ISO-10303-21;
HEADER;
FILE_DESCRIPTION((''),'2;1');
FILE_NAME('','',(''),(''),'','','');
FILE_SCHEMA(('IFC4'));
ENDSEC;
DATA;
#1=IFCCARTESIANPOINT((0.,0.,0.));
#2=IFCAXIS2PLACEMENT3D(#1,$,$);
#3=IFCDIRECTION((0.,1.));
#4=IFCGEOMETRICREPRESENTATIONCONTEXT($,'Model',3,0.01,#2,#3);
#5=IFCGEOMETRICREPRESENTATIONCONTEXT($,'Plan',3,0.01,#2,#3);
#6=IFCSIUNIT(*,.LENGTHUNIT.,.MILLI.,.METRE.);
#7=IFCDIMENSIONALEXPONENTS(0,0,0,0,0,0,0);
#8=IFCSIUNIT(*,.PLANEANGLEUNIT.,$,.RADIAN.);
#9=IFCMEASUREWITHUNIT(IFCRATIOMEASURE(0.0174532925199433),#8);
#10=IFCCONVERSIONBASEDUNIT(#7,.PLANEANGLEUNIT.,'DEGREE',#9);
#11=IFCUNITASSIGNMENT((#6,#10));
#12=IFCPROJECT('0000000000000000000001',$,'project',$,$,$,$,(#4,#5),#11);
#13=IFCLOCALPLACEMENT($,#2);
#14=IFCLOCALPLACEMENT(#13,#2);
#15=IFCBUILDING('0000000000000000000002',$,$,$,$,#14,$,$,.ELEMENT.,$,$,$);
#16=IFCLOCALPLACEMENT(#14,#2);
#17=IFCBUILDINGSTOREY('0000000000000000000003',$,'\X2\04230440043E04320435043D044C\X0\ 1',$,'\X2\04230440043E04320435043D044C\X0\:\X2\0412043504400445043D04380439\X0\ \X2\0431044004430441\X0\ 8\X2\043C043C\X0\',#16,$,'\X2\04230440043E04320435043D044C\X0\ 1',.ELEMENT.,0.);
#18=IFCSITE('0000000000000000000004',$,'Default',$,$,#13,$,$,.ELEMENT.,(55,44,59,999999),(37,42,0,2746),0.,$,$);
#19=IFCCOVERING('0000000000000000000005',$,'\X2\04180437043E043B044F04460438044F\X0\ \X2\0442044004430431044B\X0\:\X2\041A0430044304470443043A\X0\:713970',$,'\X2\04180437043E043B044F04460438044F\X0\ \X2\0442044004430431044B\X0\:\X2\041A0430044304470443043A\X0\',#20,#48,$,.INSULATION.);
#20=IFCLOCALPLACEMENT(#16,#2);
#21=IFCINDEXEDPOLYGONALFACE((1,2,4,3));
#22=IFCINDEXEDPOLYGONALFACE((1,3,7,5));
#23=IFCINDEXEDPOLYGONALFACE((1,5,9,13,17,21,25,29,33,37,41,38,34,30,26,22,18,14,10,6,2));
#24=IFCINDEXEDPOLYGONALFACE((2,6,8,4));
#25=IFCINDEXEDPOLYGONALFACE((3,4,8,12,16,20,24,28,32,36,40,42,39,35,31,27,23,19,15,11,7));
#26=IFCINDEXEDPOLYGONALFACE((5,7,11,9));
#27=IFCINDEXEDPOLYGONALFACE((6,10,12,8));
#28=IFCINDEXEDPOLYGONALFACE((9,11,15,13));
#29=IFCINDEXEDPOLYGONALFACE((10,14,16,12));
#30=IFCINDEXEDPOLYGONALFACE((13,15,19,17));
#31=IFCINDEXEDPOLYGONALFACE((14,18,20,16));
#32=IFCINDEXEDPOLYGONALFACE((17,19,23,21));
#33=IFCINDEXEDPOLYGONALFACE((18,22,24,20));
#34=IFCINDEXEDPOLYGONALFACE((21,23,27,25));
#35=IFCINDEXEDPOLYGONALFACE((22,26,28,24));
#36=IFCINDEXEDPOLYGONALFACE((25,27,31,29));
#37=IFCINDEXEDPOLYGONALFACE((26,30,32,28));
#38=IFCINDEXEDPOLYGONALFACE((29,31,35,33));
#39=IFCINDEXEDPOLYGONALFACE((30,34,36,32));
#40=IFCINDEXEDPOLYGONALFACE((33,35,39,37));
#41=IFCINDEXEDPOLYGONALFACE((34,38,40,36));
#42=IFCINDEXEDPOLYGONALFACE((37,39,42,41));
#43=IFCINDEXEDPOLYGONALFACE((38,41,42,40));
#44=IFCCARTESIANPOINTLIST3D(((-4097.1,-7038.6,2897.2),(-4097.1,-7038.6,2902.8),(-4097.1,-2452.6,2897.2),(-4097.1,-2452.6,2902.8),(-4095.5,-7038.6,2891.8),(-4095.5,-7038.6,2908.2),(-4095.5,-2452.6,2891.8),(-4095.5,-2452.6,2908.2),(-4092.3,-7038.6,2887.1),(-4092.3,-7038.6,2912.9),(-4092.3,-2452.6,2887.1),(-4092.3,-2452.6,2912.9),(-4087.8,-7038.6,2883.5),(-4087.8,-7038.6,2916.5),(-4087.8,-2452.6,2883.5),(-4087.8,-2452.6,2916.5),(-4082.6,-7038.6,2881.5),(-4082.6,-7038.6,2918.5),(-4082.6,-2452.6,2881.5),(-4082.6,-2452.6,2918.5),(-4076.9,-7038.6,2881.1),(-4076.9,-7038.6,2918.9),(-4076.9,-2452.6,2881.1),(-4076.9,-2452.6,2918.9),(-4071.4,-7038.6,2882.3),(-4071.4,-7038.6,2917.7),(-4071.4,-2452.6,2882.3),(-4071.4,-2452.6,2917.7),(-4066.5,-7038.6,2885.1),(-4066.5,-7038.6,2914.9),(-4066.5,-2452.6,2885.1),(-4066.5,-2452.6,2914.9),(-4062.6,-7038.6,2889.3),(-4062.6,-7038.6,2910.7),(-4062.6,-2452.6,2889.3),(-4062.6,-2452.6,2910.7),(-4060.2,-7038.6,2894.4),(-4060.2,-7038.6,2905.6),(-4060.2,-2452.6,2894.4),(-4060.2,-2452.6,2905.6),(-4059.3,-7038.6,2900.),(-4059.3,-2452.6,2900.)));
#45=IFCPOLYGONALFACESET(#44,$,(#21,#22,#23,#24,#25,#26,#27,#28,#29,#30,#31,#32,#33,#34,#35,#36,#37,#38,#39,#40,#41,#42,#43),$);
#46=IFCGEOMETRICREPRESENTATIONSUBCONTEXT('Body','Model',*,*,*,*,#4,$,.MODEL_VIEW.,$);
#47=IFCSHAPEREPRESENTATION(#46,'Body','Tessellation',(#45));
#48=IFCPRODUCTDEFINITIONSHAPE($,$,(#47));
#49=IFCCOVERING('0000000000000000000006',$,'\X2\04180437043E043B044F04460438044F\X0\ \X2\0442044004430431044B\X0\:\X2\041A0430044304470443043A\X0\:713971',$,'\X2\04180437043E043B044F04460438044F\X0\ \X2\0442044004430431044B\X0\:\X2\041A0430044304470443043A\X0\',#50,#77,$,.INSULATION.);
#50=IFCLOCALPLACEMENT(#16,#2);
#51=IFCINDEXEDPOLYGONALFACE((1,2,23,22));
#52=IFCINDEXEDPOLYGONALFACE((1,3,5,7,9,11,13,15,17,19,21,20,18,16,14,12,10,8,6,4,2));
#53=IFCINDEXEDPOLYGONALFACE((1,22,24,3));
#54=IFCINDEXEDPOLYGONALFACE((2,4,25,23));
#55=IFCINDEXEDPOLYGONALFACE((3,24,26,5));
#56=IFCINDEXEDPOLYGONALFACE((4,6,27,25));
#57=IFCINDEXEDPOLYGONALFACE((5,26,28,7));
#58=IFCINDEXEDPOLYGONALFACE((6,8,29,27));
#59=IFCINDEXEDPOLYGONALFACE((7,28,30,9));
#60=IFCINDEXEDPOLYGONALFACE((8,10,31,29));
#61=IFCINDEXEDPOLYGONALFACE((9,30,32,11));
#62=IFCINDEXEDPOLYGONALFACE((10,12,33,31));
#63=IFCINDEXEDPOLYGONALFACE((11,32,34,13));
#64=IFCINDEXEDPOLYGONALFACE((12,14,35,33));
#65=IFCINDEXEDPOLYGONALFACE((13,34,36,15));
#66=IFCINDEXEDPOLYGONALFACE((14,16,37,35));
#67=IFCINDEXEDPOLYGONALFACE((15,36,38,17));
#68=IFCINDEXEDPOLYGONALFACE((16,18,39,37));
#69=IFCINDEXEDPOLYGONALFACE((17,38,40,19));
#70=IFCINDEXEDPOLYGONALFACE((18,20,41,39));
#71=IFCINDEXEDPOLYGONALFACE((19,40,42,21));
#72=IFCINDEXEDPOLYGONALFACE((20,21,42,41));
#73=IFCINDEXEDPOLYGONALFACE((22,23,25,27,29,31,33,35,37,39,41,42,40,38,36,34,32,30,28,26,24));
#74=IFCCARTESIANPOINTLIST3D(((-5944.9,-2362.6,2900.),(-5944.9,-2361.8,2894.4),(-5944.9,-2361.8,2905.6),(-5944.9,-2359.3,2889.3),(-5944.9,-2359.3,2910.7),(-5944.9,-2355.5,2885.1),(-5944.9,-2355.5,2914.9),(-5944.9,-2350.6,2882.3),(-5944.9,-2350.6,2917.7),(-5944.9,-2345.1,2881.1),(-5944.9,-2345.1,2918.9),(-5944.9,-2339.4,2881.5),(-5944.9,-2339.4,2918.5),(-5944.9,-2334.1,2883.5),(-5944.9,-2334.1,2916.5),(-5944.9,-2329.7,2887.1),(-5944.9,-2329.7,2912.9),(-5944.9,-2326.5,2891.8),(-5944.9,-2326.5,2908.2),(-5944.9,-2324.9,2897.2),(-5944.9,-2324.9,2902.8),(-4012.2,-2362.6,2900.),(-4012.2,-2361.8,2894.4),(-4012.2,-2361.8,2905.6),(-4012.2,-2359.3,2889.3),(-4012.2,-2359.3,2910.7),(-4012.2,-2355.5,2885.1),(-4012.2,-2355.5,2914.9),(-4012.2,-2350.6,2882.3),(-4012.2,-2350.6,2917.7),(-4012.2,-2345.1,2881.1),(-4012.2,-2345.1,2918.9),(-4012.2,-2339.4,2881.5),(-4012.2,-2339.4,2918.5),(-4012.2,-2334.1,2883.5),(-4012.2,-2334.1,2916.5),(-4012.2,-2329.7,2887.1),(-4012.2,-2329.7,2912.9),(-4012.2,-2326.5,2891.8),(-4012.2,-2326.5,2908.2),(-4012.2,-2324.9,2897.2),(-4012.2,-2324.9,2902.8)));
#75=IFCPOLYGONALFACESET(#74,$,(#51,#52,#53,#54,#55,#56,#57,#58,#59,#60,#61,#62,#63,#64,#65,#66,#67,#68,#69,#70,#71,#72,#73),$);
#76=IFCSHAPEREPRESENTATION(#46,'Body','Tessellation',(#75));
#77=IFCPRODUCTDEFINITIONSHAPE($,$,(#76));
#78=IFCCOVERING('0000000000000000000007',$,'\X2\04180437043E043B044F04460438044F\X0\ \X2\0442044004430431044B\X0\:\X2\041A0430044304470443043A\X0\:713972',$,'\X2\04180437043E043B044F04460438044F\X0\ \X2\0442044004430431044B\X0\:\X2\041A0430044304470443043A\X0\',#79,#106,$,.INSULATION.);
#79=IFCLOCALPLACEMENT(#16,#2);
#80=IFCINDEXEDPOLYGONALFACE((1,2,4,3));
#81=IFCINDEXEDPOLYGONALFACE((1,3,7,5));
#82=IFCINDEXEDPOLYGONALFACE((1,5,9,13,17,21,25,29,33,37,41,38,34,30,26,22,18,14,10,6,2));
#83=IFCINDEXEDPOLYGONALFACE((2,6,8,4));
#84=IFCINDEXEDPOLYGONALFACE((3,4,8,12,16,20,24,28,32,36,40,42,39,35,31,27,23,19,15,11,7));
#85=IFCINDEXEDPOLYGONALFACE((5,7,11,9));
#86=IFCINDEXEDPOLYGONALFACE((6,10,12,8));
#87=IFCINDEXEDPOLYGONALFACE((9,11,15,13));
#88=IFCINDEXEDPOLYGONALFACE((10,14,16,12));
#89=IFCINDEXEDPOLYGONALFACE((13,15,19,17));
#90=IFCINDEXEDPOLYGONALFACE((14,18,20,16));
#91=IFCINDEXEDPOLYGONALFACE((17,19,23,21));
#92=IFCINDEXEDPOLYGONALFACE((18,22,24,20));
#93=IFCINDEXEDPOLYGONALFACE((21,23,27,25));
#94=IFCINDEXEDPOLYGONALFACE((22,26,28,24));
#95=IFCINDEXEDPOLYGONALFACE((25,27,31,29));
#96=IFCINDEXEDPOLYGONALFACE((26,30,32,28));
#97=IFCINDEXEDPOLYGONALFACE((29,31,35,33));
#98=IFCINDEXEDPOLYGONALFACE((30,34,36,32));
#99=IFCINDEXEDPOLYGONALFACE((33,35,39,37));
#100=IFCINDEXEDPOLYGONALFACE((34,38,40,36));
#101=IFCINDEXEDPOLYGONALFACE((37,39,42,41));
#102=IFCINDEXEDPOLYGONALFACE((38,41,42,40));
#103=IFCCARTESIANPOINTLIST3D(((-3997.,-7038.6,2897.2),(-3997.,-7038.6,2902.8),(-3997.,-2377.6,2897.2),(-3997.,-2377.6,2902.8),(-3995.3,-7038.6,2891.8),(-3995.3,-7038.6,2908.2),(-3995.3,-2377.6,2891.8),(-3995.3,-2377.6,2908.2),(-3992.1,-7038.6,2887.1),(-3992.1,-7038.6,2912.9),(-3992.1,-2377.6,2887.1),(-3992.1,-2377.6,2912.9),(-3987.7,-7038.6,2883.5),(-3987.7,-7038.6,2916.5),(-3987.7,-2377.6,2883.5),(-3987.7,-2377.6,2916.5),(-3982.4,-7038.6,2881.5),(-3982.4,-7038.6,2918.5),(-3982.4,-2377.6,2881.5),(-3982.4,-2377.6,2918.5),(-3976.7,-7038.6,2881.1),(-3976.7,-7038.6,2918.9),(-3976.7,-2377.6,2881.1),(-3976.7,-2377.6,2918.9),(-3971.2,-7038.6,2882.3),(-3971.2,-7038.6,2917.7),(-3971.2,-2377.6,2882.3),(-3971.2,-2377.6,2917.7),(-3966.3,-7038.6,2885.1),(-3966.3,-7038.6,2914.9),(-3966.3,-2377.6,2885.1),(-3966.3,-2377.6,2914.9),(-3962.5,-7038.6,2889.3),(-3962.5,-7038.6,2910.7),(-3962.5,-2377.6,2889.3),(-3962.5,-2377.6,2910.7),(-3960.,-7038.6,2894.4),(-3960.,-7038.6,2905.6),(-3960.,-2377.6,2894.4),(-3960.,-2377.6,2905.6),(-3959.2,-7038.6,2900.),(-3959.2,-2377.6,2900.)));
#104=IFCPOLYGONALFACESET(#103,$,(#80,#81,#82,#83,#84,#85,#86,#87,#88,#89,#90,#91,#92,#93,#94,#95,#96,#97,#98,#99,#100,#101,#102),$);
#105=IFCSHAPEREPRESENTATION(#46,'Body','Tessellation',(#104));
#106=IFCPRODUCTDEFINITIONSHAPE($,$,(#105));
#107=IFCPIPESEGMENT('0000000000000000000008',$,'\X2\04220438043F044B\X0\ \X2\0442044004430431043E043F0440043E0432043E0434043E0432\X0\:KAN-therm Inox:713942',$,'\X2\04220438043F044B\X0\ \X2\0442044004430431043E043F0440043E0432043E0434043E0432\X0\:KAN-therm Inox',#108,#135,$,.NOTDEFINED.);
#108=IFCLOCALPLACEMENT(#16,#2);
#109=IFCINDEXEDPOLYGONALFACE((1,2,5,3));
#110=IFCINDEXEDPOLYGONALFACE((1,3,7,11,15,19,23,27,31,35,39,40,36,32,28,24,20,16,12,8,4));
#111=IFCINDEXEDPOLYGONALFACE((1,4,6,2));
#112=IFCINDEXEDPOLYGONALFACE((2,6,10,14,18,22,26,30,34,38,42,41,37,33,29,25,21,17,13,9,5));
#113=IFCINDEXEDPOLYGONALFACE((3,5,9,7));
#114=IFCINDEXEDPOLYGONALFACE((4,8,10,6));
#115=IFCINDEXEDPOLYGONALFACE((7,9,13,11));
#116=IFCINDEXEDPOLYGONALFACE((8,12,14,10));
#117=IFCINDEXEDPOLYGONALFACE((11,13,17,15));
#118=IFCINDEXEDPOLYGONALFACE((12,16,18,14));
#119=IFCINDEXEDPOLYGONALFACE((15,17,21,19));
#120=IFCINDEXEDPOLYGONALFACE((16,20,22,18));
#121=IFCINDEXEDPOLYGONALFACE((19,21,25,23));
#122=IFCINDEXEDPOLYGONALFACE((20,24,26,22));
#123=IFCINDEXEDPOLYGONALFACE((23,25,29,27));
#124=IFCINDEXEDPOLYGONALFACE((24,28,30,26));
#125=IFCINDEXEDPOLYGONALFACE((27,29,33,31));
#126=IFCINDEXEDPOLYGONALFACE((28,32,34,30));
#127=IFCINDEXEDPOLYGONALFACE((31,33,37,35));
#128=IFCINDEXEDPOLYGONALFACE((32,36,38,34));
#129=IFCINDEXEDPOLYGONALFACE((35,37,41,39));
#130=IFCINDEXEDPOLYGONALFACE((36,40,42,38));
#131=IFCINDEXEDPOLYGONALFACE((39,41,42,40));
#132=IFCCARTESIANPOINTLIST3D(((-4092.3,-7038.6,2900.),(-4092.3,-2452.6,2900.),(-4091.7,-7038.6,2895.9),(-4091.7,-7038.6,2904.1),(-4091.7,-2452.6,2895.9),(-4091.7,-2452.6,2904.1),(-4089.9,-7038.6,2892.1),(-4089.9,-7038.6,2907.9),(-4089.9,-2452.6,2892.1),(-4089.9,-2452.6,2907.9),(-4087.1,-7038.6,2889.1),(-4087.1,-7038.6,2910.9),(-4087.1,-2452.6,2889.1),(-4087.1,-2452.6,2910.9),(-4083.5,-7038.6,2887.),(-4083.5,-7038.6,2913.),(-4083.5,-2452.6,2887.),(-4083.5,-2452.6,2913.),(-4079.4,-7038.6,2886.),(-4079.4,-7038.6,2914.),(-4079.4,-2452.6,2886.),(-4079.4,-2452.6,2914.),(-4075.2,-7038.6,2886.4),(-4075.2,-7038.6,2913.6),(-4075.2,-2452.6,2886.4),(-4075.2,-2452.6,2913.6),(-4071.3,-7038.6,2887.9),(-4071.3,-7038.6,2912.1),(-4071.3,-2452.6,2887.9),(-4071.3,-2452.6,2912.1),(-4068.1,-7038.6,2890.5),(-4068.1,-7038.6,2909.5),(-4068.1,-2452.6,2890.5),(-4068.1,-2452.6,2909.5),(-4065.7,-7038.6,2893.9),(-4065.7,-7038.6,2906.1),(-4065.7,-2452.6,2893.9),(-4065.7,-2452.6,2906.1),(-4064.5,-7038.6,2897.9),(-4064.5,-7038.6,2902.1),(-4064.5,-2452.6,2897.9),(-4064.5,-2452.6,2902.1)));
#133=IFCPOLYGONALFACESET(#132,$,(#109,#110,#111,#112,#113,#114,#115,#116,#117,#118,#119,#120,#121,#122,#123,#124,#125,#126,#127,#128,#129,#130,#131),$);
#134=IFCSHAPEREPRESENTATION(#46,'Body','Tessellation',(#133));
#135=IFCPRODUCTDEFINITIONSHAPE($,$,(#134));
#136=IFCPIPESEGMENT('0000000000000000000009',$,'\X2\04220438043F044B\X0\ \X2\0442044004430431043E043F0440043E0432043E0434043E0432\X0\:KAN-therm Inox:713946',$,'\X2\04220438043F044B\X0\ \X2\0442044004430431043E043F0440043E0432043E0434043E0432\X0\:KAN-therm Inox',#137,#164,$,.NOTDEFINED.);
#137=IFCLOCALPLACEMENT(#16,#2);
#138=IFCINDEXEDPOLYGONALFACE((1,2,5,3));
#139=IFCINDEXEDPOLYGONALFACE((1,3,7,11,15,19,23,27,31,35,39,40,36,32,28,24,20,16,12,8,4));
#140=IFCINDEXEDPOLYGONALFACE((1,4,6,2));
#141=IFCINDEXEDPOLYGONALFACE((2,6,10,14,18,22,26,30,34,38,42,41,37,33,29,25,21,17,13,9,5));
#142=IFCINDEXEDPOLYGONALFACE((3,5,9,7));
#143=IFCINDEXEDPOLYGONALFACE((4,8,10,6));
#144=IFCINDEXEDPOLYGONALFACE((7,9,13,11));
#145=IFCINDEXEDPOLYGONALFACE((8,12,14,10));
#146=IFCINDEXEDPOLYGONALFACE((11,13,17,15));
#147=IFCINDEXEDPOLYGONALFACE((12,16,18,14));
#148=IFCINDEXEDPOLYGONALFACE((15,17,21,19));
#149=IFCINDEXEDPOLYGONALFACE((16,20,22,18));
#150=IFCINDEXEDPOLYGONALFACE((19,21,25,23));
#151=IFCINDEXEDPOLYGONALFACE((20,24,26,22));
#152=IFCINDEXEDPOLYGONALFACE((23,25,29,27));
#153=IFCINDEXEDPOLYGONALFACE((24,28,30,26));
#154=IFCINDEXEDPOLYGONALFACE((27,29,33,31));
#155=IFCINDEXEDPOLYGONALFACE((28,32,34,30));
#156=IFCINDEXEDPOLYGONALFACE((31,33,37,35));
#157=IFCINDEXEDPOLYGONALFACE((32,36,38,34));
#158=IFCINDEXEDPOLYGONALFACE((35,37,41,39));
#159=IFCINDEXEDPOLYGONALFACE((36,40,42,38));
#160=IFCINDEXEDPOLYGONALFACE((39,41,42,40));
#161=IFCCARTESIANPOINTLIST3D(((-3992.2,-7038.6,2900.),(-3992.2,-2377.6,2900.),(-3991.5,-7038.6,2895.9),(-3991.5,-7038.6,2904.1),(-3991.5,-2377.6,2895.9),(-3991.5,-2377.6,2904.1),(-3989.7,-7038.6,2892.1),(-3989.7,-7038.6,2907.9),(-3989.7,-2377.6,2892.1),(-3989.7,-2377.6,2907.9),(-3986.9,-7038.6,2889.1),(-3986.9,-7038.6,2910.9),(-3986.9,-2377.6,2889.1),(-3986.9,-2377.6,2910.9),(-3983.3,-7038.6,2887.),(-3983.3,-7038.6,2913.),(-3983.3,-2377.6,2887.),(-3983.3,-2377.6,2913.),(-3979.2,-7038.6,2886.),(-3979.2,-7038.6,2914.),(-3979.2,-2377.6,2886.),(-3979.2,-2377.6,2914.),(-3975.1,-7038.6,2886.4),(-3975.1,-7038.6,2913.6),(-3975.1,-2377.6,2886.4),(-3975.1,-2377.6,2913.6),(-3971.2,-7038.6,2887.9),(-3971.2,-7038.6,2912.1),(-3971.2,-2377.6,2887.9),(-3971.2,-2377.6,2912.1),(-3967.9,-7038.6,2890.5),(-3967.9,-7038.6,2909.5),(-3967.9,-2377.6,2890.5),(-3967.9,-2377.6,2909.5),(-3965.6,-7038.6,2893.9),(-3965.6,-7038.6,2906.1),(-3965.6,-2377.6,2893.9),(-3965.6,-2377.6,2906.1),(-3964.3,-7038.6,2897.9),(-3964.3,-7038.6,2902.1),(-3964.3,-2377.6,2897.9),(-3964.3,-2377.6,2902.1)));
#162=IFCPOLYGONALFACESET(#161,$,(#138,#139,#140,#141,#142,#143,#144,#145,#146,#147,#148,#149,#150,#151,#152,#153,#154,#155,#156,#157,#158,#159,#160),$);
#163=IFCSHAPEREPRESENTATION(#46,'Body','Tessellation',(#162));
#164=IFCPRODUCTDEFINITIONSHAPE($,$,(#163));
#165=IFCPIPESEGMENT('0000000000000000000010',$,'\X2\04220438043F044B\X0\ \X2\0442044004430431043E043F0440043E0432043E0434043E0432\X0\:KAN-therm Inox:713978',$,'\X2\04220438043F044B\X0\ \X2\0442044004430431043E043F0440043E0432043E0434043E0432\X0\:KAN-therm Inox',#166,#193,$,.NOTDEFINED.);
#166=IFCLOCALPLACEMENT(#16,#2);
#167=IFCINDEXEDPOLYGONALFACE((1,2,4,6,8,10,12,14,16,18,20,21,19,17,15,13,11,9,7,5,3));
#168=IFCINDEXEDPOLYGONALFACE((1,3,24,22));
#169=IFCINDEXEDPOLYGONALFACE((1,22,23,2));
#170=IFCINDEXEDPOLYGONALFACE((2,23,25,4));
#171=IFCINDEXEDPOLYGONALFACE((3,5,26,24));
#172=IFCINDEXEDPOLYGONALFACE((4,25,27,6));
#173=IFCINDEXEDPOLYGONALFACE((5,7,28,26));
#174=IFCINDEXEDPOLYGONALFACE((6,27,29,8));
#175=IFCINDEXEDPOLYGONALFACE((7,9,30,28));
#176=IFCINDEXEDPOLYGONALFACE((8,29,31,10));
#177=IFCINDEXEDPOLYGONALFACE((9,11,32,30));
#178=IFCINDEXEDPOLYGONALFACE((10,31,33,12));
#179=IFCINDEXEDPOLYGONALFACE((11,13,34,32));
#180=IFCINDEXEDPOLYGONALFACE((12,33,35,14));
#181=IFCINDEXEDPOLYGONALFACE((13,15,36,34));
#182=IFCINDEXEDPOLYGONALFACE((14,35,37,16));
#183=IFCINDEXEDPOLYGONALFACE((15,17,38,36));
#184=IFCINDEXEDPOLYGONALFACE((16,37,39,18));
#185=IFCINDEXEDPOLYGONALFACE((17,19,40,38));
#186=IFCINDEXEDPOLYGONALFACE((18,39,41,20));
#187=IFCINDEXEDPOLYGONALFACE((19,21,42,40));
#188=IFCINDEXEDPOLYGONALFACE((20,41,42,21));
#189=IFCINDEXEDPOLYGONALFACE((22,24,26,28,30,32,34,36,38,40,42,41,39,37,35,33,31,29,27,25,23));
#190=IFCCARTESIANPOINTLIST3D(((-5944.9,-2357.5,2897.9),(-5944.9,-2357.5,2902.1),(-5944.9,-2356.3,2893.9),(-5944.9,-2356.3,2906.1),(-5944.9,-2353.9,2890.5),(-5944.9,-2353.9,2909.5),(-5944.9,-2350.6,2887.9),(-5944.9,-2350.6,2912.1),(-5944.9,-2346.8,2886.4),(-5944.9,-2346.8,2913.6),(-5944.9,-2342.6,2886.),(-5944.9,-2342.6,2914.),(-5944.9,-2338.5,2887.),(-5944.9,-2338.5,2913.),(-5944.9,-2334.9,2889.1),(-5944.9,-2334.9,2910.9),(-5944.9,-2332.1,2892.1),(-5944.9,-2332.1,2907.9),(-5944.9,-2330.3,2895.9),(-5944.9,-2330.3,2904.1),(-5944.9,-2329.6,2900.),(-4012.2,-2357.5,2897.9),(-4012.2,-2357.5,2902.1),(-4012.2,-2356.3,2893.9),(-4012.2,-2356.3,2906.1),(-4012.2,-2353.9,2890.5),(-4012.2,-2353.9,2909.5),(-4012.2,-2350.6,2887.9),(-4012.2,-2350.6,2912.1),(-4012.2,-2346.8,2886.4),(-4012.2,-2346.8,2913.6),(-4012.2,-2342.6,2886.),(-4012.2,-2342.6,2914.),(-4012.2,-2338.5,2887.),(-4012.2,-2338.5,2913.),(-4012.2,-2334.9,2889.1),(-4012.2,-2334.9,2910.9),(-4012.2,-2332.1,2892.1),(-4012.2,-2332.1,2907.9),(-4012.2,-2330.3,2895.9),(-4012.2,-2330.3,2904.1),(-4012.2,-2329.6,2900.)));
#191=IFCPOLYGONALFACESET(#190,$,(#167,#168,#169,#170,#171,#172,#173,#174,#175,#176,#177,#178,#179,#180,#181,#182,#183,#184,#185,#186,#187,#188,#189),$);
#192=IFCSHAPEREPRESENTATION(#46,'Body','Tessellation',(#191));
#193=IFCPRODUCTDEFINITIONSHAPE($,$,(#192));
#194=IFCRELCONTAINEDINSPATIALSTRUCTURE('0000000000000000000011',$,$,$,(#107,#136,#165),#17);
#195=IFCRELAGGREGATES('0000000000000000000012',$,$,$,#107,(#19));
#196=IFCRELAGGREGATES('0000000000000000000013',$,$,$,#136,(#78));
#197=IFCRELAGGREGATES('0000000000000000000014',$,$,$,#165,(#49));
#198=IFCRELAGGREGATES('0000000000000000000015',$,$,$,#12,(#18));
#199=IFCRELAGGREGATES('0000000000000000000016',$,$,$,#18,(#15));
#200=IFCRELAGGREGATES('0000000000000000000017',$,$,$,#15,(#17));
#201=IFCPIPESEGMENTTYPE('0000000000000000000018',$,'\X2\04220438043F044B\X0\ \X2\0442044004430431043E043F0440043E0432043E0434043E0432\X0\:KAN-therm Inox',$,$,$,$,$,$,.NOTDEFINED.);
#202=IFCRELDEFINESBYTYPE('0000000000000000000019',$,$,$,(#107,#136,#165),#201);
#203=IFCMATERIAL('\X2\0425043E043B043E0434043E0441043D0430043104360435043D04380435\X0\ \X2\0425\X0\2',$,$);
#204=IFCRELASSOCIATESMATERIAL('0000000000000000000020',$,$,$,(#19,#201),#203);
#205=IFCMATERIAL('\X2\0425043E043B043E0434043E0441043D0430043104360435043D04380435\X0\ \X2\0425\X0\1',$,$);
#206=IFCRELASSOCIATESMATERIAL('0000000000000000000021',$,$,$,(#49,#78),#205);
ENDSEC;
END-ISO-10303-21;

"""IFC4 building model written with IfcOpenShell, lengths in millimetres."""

from ifc_helpers import new_model, entity, si_unit, converted_unit, direction, frame, frame_2d, origin, origin_2d_with_axis, place, context, subcontext, project, spatial, circle, extrude, material, type_object, element, aggregate, save


model = new_model("IFC4")

# Units and contexts
model_context = context("Model", 3, precision=0.01, world=origin(), true_north=direction((0.0, 1.0)))
plan_context = context("Plan", 3, precision=0.01, world=origin(), true_north=direction((0.0, 1.0)))
body_context = subcontext(model_context, "Body", "Model", "MODEL_VIEW")
ifc_project = project(units=[si_unit("LENGTHUNIT", "METRE", prefix="MILLI"), converted_unit("PLANEANGLEUNIT", "DEGREE", entity("IfcRatioMeasure", 0.0174532925199433), si_unit("PLANEANGLEUNIT", "RADIAN"), dimensions=[0, 0, 0, 0, 0, 0, 0])], contexts=[model_context, plan_context])

# Site, building, storey
site_placement = place(None, origin())
site = spatial("IfcSite", under=ifc_project, at=site_placement, Name="Default", CompositionType="ELEMENT", RefLatitude=(55, 44, 59, 999999), RefLongitude=(37, 42, 0, 2746), RefElevation=0.0)
building_placement = place(site_placement, origin())
building = spatial("IfcBuilding", under=site, at=building_placement, CompositionType="ELEMENT")
storey_placement = place(building_placement, origin())
storey = spatial("IfcBuildingStorey", under=building, at=storey_placement, Name="Уровень 1", ObjectType="Уровень:Верхний брус 8мм", LongName="Уровень 1", CompositionType="ELEMENT", Elevation=0.0)

# Coverings
ifc_material_1 = material(Name="Холодоснабжение Х2")
covering_1_placement = place(storey_placement, frame((-4098.9, -7038.6, 2879.4)))
covering_1 = element("IfcCovering", 1, at=covering_1_placement, material=ifc_material_1, Name="Изоляция трубы:Каучук:713970", ObjectType="Изоляция трубы:Каучук", PredefinedType="INSULATION", context=body_context, shape_type="SweptSolid", body=[
    extrude(circle(Radius=19.0, at=origin_2d_with_axis()), frame((20.6, 0.0, 20.6), z_axis=(0.0, 1.0, 0.0), x_axis=(1.0, 0.0, 0.0)), (0.0, 0.0, 1.0), 4586.0),
])
ifc_material_2 = material(Name="Холодоснабжение Х1")
covering_2_placement = place(storey_placement, frame((-5944.9, -2364.2, 2879.4)))
covering_2 = element("IfcCovering", 2, at=covering_2_placement, material=ifc_material_2, Name="Изоляция трубы:Каучук:713971", ObjectType="Изоляция трубы:Каучук", PredefinedType="INSULATION", context=body_context, shape_type="SweptSolid", body=[
    extrude(circle(Radius=19.0, at=frame_2d((0.0, 0.0), x_axis=(1.0, 0.0))), frame((0.0, 20.6, 20.6), z_axis=(1.0, 0.0, 0.0), x_axis=(0.0, -1.0, 0.0)), (0.0, 0.0, 1.0), 1932.8),
])
covering_3_placement = place(storey_placement, frame((-3998.8, -7038.6, 2879.4)))
covering_3 = element("IfcCovering", 3, at=covering_3_placement, material=ifc_material_2, Name="Изоляция трубы:Каучук:713972", ObjectType="Изоляция трубы:Каучук", PredefinedType="INSULATION", context=body_context, shape_type="SweptSolid", body=[
    extrude(circle(Radius=19.0, at=origin_2d_with_axis()), frame((20.6, 0.0, 20.6), z_axis=(0.0, 1.0, 0.0), x_axis=(1.0, 0.0, 0.0)), (0.0, 0.0, 1.0), 4661.0),
])

# Pipe segments
pipe_segment_type_1 = type_object("IfcPipeSegmentType", Name="Типы трубопроводов:KAN-therm Inox", PredefinedType="NOTDEFINED", material=ifc_material_1)
pipe_segment_1_placement = place(storey_placement, frame((-4093.9, -7038.6, 2884.4)))
pipe_segment_1 = element("IfcPipeSegment", 4, at=pipe_segment_1_placement, inside=storey, type_object=pipe_segment_type_1, Name="Типы трубопроводов:KAN-therm Inox:713942", ObjectType="Типы трубопроводов:KAN-therm Inox", PredefinedType="NOTDEFINED", context=body_context, shape_type="SweptSolid", body=[
    extrude(circle(Radius=14.0, at=origin_2d_with_axis()), frame((15.6, 0.0, 15.6), z_axis=(0.0, 1.0, 0.0), x_axis=(-1.0, 0.0, 0.0)), (0.0, 0.0, 1.0), 4586.0),
])
aggregate(pipe_segment_1, [covering_1])
pipe_segment_2_placement = place(storey_placement, frame((-3993.8, -7038.6, 2884.4)))
pipe_segment_2 = element("IfcPipeSegment", 5, at=pipe_segment_2_placement, inside=storey, type_object=pipe_segment_type_1, Name="Типы трубопроводов:KAN-therm Inox:713946", ObjectType="Типы трубопроводов:KAN-therm Inox", PredefinedType="NOTDEFINED", context=body_context, shape_type="SweptSolid", body=[
    extrude(circle(Radius=14.0, at=origin_2d_with_axis()), frame((15.6, 0.0, 15.6), z_axis=(0.0, 1.0, 0.0), x_axis=(-1.0, 0.0, 0.0)), (0.0, 0.0, 1.0), 4661.0),
])
aggregate(pipe_segment_2, [covering_3])
pipe_segment_3_placement = place(storey_placement, frame((-5944.9, -2359.2, 2884.4)))
pipe_segment_3 = element("IfcPipeSegment", 6, at=pipe_segment_3_placement, inside=storey, type_object=pipe_segment_type_1, Name="Типы трубопроводов:KAN-therm Inox:713978", ObjectType="Типы трубопроводов:KAN-therm Inox", PredefinedType="NOTDEFINED", context=body_context, shape_type="SweptSolid", body=[
    extrude(circle(Radius=14.0, at=frame_2d((0.0, 0.0), x_axis=(1.0, 0.0))), frame((0.0, 15.6, 15.6), z_axis=(1.0, 0.0, 0.0), x_axis=(0.0, 1.0, 0.0)), (0.0, 0.0, 1.0), 1932.8),
])
aggregate(pipe_segment_3, [covering_2])

save(model, "model.ifc")
